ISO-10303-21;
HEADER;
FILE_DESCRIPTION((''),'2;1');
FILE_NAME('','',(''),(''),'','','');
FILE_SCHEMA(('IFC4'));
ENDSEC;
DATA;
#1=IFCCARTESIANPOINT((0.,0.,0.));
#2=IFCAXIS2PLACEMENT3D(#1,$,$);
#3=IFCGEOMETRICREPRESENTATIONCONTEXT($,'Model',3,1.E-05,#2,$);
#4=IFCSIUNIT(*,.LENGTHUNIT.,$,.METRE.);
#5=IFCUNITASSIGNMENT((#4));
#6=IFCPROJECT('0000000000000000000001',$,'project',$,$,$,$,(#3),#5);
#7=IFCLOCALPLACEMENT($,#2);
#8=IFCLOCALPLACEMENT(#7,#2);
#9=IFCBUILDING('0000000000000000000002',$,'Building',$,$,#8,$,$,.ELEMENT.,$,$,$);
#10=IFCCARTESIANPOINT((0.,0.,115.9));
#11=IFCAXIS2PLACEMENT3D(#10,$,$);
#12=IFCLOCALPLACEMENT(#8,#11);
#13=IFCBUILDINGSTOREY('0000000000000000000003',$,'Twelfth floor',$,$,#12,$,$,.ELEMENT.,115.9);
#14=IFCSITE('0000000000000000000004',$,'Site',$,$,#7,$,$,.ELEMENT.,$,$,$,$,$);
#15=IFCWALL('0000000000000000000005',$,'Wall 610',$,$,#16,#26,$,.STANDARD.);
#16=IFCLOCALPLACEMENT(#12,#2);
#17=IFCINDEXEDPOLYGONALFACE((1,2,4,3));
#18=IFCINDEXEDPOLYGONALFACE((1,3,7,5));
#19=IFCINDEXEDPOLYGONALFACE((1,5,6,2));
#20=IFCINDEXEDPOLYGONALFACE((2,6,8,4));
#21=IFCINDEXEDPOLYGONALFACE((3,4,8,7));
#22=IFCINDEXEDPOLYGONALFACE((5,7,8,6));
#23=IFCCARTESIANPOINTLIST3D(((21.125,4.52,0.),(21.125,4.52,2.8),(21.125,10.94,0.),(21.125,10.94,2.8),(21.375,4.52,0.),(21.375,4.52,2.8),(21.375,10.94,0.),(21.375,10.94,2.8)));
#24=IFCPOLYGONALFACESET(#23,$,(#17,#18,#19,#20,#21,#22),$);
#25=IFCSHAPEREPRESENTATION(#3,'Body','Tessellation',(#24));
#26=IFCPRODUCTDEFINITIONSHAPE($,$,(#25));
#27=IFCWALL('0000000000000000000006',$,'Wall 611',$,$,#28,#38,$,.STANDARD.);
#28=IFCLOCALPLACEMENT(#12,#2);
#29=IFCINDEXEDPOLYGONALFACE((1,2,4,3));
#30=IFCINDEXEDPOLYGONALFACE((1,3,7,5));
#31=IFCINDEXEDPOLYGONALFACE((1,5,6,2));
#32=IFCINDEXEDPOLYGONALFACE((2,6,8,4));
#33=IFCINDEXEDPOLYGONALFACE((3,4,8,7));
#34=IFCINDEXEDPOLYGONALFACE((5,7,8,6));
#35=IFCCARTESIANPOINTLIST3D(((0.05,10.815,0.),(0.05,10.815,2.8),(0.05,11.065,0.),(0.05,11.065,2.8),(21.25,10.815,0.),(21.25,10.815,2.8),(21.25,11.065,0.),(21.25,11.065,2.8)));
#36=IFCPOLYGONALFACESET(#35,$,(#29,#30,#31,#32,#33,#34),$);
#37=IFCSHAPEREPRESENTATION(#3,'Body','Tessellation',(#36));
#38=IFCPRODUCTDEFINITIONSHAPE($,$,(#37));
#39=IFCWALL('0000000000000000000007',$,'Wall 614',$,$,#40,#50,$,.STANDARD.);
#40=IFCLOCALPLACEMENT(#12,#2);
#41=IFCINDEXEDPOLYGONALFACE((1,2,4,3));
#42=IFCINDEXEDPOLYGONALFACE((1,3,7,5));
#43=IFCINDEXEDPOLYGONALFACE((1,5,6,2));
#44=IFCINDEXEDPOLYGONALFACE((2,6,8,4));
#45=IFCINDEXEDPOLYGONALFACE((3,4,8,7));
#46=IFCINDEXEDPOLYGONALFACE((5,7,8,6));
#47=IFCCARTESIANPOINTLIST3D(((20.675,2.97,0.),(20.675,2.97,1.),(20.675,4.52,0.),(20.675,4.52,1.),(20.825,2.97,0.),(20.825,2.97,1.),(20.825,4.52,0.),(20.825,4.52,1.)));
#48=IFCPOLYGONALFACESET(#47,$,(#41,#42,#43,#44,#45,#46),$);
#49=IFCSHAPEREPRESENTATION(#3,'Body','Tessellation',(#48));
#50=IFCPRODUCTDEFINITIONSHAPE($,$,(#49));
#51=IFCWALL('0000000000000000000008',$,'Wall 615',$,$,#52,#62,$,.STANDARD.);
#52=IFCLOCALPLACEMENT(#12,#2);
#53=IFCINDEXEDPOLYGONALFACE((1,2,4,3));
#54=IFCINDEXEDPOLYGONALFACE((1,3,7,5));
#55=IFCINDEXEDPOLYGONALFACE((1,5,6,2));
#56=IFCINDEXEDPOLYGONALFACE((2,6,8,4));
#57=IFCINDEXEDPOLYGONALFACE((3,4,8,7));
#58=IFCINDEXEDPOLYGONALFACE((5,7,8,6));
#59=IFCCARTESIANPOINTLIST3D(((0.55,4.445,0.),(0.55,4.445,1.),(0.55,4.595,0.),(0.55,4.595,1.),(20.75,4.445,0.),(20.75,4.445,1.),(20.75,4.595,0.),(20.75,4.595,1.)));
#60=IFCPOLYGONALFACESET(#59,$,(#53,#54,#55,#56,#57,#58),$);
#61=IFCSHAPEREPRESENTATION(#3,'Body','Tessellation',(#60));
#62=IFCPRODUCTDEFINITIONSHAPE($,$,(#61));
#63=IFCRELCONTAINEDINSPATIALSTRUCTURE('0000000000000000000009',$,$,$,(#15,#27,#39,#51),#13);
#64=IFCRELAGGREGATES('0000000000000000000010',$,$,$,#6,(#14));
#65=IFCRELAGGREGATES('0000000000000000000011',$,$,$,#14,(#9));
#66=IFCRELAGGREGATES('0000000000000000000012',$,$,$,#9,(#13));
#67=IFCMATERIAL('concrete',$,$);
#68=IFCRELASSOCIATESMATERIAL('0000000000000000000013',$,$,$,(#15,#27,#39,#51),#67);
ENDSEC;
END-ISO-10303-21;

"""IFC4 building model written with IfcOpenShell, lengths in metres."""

from ifc_helpers import new_model, si_unit, frame, frame_2d, origin, place, context, project, spatial, rectangle, extrude, material, element, save


model = new_model("IFC4")

# Units and contexts
model_context = context("Model", 3, precision=1e-05, world=origin())
ifc_project = project(units=[si_unit("LENGTHUNIT", "METRE")], contexts=[model_context])

# Site, building, storey
site_placement = place(None, origin())
site = spatial("IfcSite", under=ifc_project, at=site_placement, Name="Site", CompositionType="ELEMENT")
building_placement = place(site_placement, origin())
building = spatial("IfcBuilding", under=site, at=building_placement, Name="Building", CompositionType="ELEMENT")
storey_placement = place(building_placement, frame((0.0, 0.0, 115.9)))
storey = spatial("IfcBuildingStorey", under=building, at=storey_placement, Name="Twelfth floor", CompositionType="ELEMENT", Elevation=115.9)

# Walls
ifc_material = material(Name="concrete")
wall_1_placement = place(storey_placement, frame((21.25, 4.52, 0.0), z_axis=(0.0, 0.0, 1.0), x_axis=(0.0, 1.0, 0.0)))
element("IfcWall", 1, at=wall_1_placement, inside=storey, material=ifc_material, Name="Wall 610", PredefinedType="STANDARD", context=model_context, shape_type="SweptSolid", body=[
    extrude(rectangle(XDim=6.42, YDim=0.25, at=frame_2d((3.21, 0.0))), origin(), (0.0, 0.0, 1.0), 2.8),
])
wall_2_placement = place(storey_placement, frame((21.25, 10.94, 0.0), z_axis=(0.0, 0.0, 1.0), x_axis=(-1.0, 0.0, 0.0)))
element("IfcWall", 2, at=wall_2_placement, inside=storey, material=ifc_material, Name="Wall 611", PredefinedType="STANDARD", context=model_context, shape_type="SweptSolid", body=[
    extrude(rectangle(XDim=21.2, YDim=0.25, at=frame_2d((10.6, 0.0))), origin(), (0.0, 0.0, 1.0), 2.8),
])
wall_3_placement = place(storey_placement, frame((20.75, 2.97, 0.0), z_axis=(0.0, 0.0, 1.0), x_axis=(0.0, 1.0, 0.0)))
element("IfcWall", 3, at=wall_3_placement, inside=storey, material=ifc_material, Name="Wall 614", PredefinedType="STANDARD", context=model_context, shape_type="SweptSolid", body=[
    extrude(rectangle(XDim=1.55, YDim=0.15, at=frame_2d((0.775, 0.0))), origin(), (0.0, 0.0, 1.0), 1.0),
])
wall_4_placement = place(storey_placement, frame((20.75, 4.52, 0.0), z_axis=(0.0, 0.0, 1.0), x_axis=(-1.0, 0.0, 0.0)))
element("IfcWall", 4, at=wall_4_placement, inside=storey, material=ifc_material, Name="Wall 615", PredefinedType="STANDARD", context=model_context, shape_type="SweptSolid", body=[
    extrude(rectangle(XDim=20.2, YDim=0.15, at=frame_2d((10.1, 0.0))), origin(), (0.0, 0.0, 1.0), 1.0),
])

save(model, "model.ifc")
